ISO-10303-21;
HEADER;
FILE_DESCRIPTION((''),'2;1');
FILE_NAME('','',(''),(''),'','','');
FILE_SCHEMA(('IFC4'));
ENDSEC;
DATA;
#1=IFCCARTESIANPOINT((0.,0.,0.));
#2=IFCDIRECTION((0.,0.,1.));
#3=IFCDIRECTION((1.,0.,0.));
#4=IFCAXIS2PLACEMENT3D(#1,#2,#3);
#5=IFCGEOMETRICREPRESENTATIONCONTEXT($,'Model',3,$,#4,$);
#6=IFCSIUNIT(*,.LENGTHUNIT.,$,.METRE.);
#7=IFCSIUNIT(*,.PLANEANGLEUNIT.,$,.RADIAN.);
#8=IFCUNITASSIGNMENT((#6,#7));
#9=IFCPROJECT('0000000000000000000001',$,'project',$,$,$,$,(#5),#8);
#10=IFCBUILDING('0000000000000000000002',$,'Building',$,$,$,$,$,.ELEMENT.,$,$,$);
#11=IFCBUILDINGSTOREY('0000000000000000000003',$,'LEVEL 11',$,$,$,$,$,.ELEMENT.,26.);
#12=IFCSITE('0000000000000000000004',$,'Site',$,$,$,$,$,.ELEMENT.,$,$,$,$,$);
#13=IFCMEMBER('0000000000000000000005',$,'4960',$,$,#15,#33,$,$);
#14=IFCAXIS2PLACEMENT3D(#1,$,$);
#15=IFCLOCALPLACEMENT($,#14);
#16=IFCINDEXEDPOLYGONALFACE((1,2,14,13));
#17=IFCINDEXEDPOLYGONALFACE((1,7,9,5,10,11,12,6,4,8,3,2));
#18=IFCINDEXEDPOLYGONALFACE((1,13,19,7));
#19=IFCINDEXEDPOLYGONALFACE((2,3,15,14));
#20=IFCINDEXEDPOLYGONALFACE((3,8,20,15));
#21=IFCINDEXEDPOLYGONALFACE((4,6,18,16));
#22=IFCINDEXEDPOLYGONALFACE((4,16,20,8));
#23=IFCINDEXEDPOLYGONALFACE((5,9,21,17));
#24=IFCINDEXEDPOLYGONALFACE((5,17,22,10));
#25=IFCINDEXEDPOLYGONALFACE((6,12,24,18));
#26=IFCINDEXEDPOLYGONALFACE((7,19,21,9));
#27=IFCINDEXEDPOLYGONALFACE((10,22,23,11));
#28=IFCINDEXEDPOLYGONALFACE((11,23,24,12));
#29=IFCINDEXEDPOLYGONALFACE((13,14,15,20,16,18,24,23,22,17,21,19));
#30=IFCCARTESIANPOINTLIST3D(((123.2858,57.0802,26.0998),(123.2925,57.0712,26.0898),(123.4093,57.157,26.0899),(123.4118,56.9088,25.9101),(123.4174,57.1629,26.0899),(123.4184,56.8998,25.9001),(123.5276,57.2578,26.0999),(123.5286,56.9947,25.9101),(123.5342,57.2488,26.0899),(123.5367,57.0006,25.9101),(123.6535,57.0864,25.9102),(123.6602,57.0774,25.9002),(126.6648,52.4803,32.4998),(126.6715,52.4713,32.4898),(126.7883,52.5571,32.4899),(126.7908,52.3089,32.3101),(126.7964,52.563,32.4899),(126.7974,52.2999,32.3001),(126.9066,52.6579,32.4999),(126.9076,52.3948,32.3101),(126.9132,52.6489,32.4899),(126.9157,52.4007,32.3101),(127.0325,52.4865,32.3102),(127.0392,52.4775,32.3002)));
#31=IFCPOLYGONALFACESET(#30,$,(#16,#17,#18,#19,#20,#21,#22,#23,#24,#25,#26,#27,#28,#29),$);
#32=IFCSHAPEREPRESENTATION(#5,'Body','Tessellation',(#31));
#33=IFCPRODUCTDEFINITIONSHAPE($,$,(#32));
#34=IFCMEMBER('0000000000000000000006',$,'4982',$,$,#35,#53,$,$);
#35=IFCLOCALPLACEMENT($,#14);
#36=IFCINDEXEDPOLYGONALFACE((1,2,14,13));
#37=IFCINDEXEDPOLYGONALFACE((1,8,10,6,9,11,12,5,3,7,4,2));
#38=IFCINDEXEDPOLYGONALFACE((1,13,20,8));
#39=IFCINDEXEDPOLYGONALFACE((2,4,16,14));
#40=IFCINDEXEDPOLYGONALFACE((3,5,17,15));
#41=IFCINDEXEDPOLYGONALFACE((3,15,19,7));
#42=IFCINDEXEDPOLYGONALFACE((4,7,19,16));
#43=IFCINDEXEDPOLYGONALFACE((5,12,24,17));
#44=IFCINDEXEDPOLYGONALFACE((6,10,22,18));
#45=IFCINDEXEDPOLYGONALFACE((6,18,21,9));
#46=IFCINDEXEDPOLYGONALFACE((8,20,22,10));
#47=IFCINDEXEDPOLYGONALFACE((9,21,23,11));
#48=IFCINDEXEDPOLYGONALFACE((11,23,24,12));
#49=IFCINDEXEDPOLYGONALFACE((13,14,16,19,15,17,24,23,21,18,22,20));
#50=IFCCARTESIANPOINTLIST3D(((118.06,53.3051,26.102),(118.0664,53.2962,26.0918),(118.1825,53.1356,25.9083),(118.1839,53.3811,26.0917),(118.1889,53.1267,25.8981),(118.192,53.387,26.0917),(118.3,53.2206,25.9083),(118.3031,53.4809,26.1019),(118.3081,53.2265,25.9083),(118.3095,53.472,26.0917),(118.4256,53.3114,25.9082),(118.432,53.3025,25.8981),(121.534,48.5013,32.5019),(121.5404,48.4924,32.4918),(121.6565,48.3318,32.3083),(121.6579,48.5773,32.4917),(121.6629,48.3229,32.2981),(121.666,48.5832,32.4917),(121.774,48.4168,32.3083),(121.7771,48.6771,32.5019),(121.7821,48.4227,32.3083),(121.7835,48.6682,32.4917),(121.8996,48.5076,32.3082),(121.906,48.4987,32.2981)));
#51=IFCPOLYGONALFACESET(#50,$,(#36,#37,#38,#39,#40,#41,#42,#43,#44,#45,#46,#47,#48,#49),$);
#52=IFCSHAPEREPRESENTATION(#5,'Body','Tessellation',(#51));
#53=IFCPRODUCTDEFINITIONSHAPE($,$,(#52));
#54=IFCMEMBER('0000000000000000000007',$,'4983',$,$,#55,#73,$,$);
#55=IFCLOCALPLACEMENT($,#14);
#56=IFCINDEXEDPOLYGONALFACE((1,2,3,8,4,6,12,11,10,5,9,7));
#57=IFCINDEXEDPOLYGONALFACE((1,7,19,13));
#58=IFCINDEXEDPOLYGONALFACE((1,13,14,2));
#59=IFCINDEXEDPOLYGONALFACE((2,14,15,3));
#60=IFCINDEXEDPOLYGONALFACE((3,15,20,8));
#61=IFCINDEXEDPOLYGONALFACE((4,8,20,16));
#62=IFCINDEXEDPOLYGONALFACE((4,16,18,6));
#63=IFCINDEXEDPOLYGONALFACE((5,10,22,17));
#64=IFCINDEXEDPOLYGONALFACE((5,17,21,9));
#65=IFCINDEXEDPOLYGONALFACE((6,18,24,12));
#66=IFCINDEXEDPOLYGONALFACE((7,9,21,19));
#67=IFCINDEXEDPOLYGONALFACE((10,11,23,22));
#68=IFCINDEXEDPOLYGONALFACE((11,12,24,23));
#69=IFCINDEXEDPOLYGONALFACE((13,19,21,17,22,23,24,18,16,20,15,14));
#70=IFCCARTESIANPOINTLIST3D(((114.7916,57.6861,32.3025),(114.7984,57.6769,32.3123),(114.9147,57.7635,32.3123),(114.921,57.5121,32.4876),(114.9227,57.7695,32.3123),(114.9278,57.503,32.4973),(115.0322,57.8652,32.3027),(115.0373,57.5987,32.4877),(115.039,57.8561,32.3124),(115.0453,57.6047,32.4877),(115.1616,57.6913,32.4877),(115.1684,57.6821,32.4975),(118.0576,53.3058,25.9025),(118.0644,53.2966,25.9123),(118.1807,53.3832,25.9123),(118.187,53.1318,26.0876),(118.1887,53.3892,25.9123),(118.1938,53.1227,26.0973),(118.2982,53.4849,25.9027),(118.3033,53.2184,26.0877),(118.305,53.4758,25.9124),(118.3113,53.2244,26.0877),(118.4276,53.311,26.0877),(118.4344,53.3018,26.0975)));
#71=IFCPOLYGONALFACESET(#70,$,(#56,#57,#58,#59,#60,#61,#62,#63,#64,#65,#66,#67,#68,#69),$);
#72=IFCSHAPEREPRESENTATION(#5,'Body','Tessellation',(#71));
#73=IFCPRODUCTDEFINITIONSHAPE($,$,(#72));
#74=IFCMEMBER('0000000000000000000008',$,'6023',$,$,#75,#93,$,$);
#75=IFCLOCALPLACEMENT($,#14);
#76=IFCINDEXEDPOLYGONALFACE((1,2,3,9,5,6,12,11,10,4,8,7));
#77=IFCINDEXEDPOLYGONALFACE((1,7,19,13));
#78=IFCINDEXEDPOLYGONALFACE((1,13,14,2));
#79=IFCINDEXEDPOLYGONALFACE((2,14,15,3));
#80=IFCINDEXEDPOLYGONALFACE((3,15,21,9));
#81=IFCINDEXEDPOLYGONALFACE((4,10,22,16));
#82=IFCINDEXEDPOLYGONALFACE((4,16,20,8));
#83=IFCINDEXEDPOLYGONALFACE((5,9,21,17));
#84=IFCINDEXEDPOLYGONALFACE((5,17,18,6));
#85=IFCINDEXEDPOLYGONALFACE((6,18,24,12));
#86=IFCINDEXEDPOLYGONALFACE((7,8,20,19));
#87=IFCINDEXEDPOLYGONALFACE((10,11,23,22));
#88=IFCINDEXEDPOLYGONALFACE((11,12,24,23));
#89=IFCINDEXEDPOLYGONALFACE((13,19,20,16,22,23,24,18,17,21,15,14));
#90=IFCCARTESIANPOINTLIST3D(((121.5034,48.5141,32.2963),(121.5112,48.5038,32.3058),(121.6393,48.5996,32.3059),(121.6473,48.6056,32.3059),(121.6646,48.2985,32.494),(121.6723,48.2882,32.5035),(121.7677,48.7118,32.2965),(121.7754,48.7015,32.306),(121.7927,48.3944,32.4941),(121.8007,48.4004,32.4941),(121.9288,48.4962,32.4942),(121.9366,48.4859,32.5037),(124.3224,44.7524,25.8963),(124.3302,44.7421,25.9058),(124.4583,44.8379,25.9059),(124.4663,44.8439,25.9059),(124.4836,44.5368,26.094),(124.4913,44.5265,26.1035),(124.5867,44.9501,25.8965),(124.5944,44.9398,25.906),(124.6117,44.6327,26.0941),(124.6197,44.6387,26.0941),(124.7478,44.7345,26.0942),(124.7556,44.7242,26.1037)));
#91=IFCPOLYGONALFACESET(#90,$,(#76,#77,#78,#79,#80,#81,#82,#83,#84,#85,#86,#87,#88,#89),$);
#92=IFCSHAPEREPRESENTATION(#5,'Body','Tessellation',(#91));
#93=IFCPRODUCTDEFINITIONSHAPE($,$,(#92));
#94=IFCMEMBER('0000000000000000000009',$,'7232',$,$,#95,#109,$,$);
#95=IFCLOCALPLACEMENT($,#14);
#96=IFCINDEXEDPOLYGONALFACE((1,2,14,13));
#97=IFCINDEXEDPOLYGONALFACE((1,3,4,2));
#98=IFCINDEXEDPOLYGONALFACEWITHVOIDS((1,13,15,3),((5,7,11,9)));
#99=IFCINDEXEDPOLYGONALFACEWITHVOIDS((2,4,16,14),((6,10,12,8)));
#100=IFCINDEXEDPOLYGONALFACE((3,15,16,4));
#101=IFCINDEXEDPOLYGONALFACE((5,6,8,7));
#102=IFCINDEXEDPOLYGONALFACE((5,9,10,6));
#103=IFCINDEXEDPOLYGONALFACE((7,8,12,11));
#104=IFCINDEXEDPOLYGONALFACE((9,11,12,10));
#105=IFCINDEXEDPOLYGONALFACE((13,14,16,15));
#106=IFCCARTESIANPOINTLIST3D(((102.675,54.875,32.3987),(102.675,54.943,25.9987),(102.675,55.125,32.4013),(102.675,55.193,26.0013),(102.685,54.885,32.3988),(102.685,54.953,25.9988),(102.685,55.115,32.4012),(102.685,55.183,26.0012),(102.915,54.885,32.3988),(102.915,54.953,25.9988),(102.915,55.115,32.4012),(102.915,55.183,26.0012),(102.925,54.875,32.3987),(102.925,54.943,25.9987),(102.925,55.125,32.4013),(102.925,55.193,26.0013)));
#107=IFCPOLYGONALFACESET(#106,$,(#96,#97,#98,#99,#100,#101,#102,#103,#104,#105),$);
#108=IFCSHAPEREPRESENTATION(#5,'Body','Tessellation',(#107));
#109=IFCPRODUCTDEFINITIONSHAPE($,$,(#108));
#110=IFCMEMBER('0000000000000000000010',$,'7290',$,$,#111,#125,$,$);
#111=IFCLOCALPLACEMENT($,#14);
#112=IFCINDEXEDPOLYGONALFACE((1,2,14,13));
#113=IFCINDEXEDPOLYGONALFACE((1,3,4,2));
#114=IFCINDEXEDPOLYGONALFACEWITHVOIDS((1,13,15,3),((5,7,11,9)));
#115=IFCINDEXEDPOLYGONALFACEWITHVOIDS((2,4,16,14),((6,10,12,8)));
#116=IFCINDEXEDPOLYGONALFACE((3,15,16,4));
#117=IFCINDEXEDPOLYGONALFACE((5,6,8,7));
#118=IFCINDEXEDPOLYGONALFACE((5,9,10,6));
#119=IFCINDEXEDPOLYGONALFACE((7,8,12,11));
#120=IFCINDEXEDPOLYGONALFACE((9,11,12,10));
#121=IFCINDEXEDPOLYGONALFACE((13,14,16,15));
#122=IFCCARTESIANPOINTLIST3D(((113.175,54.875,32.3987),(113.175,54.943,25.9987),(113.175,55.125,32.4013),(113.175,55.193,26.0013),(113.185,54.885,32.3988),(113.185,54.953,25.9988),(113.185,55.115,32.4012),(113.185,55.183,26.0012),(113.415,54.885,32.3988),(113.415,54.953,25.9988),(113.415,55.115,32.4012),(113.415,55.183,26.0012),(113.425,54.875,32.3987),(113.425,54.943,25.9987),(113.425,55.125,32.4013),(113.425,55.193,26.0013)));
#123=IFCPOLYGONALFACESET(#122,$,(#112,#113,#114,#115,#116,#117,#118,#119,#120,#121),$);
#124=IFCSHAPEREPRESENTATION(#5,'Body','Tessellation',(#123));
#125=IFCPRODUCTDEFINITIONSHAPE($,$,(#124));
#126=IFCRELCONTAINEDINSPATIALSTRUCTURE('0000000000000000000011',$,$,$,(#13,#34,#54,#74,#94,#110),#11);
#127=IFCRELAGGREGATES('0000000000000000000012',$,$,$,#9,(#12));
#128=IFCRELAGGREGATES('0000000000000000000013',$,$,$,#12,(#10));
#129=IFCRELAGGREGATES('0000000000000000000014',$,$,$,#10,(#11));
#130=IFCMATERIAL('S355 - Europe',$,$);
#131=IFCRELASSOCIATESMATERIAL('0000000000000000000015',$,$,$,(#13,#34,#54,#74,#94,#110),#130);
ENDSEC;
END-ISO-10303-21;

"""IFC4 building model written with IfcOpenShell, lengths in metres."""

from ifc_helpers import new_model, si_unit, frame, origin_with_axes, origin_2d_with_axis, place, context, project, spatial, hollow_rectangle, i_section, extrude, material, material_profile, profile_set, profile_usage, element, save


model = new_model("IFC4")

# Units and contexts
model_context = context("Model", 3, world=origin_with_axes())
ifc_project = project(units=[si_unit("LENGTHUNIT", "METRE"), si_unit("PLANEANGLEUNIT", "RADIAN")], contexts=[model_context])

# Site, building, storey
site = spatial("IfcSite", under=ifc_project, Name="Site", CompositionType="ELEMENT")
building = spatial("IfcBuilding", under=site, Name="Building", CompositionType="ELEMENT")
storey = spatial("IfcBuildingStorey", under=building, Name="LEVEL 11", CompositionType="ELEMENT", Elevation=26.0)

# Shared definitions
ifc_material = material(Name="S355 - Europe")

# Members
ifc_material_profile_1 = material_profile(ifc_material, i_section(OverallWidth=0.3, OverallDepth=0.3, WebThickness=0.01, FlangeThickness=0.015, at=origin_2d_with_axis()))
ifc_profile_set_1 = profile_set([ifc_material_profile_1])
ifc_profile_usage_1 = profile_usage(ifc_profile_set_1, cardinal=10)
member_1_placement = place(None, frame((126.852, 52.4789, 32.4), z_axis=(-0.394036, 0.536409, -0.746325), x_axis=(-0.805765, -0.592235, 0.0)))
element("IfcMember", 1, at=member_1_placement, inside=storey, material=ifc_profile_usage_1, Name="4960", context=model_context, shape_type="SweptSolid", body=[
    extrude(i_section(OverallWidth=0.3, OverallDepth=0.3, WebThickness=0.01, FlangeThickness=0.015, at=origin_2d_with_axis()), origin_with_axes(), (0.0, 0.0, 1.0), 8.5754),
])
ifc_material_profile_2 = material_profile(ifc_material, i_section(OverallWidth=0.3, OverallDepth=0.3, WebThickness=0.01, FlangeThickness=0.015, at=origin_2d_with_axis()))
ifc_profile_set_2 = profile_set([ifc_material_profile_2])
ifc_profile_usage_2 = profile_usage(ifc_profile_set_2, cardinal=10)
member_2_placement = place(None, frame((121.72, 48.5, 32.4), z_axis=(-0.39822, 0.550653, -0.733623), x_axis=(-0.810441, -0.585821, 0.0)))
element("IfcMember", 2, at=member_2_placement, inside=storey, material=ifc_profile_usage_2, Name="4982", context=model_context, shape_type="SweptSolid", body=[
    extrude(i_section(OverallWidth=0.3, OverallDepth=0.3, WebThickness=0.01, FlangeThickness=0.015, at=origin_2d_with_axis()), origin_with_axes(), (0.0, 0.0, 1.0), 8.7238),
])
ifc_material_profile_3 = material_profile(ifc_material, i_section(OverallWidth=0.3, OverallDepth=0.3, WebThickness=0.01, FlangeThickness=0.015, at=origin_2d_with_axis()))
ifc_profile_set_3 = profile_set([ifc_material_profile_3])
ifc_profile_usage_3 = profile_usage(ifc_profile_set_3, cardinal=10)
member_3_placement = place(None, frame((118.246, 53.3038, 26.0), z_axis=(-0.388112, 0.520529, 0.760538), x_axis=(-0.802364, -0.596835, 0.0)))
element("IfcMember", 3, at=member_3_placement, inside=storey, material=ifc_profile_usage_3, Name="4983", context=model_context, shape_type="SweptSolid", body=[
    extrude(i_section(OverallWidth=0.3, OverallDepth=0.3, WebThickness=0.01, FlangeThickness=0.015, at=origin_2d_with_axis()), origin_with_axes(), (0.0, 0.0, 1.0), 8.4151),
])
ifc_material_profile_4 = material_profile(ifc_material, i_section(OverallWidth=0.33, OverallDepth=0.35, WebThickness=0.01, FlangeThickness=0.016, at=origin_2d_with_axis()))
ifc_profile_set_4 = profile_set([ifc_material_profile_4])
ifc_profile_usage_4 = profile_usage(ifc_profile_set_4, cardinal=10)
member_4_placement = place(None, frame((121.72, 48.5, 32.4), z_axis=(0.355, -0.473715, -0.805959), x_axis=(0.800963, 0.598714, 0.0)))
element("IfcMember", 4, at=member_4_placement, inside=storey, material=ifc_profile_usage_4, Name="6023", context=model_context, shape_type="SweptSolid", body=[
    extrude(i_section(OverallWidth=0.33, OverallDepth=0.35, WebThickness=0.01, FlangeThickness=0.016, at=origin_2d_with_axis()), origin_with_axes(), (0.0, 0.0, 1.0), 7.9409),
])
ifc_material_profile_5 = material_profile(ifc_material, hollow_rectangle(XDim=0.25, YDim=0.25, WallThickness=0.01, at=origin_2d_with_axis()))
ifc_profile_set_5 = profile_set([ifc_material_profile_5])
ifc_profile_usage_5 = profile_usage(ifc_profile_set_5, cardinal=10)
member_5_placement = place(None, frame((102.8, 55.068, 26.0), z_axis=(0.0, -0.010624, 0.999944), x_axis=(1.0, 0.0, 0.0)))
element("IfcMember", 5, at=member_5_placement, inside=storey, material=ifc_profile_usage_5, Name="7232", context=model_context, shape_type="SweptSolid", body=[
    extrude(hollow_rectangle(XDim=0.25, YDim=0.25, WallThickness=0.01, at=origin_2d_with_axis()), origin_with_axes(), (0.0, 0.0, 1.0), 6.4004),
])
ifc_material_profile_6 = material_profile(ifc_material, hollow_rectangle(XDim=0.25, YDim=0.25, WallThickness=0.01, at=origin_2d_with_axis()))
ifc_profile_set_6 = profile_set([ifc_material_profile_6])
ifc_profile_usage_6 = profile_usage(ifc_profile_set_6, cardinal=10)
member_6_placement = place(None, frame((113.3, 55.068, 26.0), z_axis=(0.0, -0.010624, 0.999944), x_axis=(1.0, 0.0, 0.0)))
element("IfcMember", 6, at=member_6_placement, inside=storey, material=ifc_profile_usage_6, Name="7290", context=model_context, shape_type="SweptSolid", body=[
    extrude(hollow_rectangle(XDim=0.25, YDim=0.25, WallThickness=0.01, at=origin_2d_with_axis()), origin_with_axes(), (0.0, 0.0, 1.0), 6.4004),
])

save(model, "model.ifc")
